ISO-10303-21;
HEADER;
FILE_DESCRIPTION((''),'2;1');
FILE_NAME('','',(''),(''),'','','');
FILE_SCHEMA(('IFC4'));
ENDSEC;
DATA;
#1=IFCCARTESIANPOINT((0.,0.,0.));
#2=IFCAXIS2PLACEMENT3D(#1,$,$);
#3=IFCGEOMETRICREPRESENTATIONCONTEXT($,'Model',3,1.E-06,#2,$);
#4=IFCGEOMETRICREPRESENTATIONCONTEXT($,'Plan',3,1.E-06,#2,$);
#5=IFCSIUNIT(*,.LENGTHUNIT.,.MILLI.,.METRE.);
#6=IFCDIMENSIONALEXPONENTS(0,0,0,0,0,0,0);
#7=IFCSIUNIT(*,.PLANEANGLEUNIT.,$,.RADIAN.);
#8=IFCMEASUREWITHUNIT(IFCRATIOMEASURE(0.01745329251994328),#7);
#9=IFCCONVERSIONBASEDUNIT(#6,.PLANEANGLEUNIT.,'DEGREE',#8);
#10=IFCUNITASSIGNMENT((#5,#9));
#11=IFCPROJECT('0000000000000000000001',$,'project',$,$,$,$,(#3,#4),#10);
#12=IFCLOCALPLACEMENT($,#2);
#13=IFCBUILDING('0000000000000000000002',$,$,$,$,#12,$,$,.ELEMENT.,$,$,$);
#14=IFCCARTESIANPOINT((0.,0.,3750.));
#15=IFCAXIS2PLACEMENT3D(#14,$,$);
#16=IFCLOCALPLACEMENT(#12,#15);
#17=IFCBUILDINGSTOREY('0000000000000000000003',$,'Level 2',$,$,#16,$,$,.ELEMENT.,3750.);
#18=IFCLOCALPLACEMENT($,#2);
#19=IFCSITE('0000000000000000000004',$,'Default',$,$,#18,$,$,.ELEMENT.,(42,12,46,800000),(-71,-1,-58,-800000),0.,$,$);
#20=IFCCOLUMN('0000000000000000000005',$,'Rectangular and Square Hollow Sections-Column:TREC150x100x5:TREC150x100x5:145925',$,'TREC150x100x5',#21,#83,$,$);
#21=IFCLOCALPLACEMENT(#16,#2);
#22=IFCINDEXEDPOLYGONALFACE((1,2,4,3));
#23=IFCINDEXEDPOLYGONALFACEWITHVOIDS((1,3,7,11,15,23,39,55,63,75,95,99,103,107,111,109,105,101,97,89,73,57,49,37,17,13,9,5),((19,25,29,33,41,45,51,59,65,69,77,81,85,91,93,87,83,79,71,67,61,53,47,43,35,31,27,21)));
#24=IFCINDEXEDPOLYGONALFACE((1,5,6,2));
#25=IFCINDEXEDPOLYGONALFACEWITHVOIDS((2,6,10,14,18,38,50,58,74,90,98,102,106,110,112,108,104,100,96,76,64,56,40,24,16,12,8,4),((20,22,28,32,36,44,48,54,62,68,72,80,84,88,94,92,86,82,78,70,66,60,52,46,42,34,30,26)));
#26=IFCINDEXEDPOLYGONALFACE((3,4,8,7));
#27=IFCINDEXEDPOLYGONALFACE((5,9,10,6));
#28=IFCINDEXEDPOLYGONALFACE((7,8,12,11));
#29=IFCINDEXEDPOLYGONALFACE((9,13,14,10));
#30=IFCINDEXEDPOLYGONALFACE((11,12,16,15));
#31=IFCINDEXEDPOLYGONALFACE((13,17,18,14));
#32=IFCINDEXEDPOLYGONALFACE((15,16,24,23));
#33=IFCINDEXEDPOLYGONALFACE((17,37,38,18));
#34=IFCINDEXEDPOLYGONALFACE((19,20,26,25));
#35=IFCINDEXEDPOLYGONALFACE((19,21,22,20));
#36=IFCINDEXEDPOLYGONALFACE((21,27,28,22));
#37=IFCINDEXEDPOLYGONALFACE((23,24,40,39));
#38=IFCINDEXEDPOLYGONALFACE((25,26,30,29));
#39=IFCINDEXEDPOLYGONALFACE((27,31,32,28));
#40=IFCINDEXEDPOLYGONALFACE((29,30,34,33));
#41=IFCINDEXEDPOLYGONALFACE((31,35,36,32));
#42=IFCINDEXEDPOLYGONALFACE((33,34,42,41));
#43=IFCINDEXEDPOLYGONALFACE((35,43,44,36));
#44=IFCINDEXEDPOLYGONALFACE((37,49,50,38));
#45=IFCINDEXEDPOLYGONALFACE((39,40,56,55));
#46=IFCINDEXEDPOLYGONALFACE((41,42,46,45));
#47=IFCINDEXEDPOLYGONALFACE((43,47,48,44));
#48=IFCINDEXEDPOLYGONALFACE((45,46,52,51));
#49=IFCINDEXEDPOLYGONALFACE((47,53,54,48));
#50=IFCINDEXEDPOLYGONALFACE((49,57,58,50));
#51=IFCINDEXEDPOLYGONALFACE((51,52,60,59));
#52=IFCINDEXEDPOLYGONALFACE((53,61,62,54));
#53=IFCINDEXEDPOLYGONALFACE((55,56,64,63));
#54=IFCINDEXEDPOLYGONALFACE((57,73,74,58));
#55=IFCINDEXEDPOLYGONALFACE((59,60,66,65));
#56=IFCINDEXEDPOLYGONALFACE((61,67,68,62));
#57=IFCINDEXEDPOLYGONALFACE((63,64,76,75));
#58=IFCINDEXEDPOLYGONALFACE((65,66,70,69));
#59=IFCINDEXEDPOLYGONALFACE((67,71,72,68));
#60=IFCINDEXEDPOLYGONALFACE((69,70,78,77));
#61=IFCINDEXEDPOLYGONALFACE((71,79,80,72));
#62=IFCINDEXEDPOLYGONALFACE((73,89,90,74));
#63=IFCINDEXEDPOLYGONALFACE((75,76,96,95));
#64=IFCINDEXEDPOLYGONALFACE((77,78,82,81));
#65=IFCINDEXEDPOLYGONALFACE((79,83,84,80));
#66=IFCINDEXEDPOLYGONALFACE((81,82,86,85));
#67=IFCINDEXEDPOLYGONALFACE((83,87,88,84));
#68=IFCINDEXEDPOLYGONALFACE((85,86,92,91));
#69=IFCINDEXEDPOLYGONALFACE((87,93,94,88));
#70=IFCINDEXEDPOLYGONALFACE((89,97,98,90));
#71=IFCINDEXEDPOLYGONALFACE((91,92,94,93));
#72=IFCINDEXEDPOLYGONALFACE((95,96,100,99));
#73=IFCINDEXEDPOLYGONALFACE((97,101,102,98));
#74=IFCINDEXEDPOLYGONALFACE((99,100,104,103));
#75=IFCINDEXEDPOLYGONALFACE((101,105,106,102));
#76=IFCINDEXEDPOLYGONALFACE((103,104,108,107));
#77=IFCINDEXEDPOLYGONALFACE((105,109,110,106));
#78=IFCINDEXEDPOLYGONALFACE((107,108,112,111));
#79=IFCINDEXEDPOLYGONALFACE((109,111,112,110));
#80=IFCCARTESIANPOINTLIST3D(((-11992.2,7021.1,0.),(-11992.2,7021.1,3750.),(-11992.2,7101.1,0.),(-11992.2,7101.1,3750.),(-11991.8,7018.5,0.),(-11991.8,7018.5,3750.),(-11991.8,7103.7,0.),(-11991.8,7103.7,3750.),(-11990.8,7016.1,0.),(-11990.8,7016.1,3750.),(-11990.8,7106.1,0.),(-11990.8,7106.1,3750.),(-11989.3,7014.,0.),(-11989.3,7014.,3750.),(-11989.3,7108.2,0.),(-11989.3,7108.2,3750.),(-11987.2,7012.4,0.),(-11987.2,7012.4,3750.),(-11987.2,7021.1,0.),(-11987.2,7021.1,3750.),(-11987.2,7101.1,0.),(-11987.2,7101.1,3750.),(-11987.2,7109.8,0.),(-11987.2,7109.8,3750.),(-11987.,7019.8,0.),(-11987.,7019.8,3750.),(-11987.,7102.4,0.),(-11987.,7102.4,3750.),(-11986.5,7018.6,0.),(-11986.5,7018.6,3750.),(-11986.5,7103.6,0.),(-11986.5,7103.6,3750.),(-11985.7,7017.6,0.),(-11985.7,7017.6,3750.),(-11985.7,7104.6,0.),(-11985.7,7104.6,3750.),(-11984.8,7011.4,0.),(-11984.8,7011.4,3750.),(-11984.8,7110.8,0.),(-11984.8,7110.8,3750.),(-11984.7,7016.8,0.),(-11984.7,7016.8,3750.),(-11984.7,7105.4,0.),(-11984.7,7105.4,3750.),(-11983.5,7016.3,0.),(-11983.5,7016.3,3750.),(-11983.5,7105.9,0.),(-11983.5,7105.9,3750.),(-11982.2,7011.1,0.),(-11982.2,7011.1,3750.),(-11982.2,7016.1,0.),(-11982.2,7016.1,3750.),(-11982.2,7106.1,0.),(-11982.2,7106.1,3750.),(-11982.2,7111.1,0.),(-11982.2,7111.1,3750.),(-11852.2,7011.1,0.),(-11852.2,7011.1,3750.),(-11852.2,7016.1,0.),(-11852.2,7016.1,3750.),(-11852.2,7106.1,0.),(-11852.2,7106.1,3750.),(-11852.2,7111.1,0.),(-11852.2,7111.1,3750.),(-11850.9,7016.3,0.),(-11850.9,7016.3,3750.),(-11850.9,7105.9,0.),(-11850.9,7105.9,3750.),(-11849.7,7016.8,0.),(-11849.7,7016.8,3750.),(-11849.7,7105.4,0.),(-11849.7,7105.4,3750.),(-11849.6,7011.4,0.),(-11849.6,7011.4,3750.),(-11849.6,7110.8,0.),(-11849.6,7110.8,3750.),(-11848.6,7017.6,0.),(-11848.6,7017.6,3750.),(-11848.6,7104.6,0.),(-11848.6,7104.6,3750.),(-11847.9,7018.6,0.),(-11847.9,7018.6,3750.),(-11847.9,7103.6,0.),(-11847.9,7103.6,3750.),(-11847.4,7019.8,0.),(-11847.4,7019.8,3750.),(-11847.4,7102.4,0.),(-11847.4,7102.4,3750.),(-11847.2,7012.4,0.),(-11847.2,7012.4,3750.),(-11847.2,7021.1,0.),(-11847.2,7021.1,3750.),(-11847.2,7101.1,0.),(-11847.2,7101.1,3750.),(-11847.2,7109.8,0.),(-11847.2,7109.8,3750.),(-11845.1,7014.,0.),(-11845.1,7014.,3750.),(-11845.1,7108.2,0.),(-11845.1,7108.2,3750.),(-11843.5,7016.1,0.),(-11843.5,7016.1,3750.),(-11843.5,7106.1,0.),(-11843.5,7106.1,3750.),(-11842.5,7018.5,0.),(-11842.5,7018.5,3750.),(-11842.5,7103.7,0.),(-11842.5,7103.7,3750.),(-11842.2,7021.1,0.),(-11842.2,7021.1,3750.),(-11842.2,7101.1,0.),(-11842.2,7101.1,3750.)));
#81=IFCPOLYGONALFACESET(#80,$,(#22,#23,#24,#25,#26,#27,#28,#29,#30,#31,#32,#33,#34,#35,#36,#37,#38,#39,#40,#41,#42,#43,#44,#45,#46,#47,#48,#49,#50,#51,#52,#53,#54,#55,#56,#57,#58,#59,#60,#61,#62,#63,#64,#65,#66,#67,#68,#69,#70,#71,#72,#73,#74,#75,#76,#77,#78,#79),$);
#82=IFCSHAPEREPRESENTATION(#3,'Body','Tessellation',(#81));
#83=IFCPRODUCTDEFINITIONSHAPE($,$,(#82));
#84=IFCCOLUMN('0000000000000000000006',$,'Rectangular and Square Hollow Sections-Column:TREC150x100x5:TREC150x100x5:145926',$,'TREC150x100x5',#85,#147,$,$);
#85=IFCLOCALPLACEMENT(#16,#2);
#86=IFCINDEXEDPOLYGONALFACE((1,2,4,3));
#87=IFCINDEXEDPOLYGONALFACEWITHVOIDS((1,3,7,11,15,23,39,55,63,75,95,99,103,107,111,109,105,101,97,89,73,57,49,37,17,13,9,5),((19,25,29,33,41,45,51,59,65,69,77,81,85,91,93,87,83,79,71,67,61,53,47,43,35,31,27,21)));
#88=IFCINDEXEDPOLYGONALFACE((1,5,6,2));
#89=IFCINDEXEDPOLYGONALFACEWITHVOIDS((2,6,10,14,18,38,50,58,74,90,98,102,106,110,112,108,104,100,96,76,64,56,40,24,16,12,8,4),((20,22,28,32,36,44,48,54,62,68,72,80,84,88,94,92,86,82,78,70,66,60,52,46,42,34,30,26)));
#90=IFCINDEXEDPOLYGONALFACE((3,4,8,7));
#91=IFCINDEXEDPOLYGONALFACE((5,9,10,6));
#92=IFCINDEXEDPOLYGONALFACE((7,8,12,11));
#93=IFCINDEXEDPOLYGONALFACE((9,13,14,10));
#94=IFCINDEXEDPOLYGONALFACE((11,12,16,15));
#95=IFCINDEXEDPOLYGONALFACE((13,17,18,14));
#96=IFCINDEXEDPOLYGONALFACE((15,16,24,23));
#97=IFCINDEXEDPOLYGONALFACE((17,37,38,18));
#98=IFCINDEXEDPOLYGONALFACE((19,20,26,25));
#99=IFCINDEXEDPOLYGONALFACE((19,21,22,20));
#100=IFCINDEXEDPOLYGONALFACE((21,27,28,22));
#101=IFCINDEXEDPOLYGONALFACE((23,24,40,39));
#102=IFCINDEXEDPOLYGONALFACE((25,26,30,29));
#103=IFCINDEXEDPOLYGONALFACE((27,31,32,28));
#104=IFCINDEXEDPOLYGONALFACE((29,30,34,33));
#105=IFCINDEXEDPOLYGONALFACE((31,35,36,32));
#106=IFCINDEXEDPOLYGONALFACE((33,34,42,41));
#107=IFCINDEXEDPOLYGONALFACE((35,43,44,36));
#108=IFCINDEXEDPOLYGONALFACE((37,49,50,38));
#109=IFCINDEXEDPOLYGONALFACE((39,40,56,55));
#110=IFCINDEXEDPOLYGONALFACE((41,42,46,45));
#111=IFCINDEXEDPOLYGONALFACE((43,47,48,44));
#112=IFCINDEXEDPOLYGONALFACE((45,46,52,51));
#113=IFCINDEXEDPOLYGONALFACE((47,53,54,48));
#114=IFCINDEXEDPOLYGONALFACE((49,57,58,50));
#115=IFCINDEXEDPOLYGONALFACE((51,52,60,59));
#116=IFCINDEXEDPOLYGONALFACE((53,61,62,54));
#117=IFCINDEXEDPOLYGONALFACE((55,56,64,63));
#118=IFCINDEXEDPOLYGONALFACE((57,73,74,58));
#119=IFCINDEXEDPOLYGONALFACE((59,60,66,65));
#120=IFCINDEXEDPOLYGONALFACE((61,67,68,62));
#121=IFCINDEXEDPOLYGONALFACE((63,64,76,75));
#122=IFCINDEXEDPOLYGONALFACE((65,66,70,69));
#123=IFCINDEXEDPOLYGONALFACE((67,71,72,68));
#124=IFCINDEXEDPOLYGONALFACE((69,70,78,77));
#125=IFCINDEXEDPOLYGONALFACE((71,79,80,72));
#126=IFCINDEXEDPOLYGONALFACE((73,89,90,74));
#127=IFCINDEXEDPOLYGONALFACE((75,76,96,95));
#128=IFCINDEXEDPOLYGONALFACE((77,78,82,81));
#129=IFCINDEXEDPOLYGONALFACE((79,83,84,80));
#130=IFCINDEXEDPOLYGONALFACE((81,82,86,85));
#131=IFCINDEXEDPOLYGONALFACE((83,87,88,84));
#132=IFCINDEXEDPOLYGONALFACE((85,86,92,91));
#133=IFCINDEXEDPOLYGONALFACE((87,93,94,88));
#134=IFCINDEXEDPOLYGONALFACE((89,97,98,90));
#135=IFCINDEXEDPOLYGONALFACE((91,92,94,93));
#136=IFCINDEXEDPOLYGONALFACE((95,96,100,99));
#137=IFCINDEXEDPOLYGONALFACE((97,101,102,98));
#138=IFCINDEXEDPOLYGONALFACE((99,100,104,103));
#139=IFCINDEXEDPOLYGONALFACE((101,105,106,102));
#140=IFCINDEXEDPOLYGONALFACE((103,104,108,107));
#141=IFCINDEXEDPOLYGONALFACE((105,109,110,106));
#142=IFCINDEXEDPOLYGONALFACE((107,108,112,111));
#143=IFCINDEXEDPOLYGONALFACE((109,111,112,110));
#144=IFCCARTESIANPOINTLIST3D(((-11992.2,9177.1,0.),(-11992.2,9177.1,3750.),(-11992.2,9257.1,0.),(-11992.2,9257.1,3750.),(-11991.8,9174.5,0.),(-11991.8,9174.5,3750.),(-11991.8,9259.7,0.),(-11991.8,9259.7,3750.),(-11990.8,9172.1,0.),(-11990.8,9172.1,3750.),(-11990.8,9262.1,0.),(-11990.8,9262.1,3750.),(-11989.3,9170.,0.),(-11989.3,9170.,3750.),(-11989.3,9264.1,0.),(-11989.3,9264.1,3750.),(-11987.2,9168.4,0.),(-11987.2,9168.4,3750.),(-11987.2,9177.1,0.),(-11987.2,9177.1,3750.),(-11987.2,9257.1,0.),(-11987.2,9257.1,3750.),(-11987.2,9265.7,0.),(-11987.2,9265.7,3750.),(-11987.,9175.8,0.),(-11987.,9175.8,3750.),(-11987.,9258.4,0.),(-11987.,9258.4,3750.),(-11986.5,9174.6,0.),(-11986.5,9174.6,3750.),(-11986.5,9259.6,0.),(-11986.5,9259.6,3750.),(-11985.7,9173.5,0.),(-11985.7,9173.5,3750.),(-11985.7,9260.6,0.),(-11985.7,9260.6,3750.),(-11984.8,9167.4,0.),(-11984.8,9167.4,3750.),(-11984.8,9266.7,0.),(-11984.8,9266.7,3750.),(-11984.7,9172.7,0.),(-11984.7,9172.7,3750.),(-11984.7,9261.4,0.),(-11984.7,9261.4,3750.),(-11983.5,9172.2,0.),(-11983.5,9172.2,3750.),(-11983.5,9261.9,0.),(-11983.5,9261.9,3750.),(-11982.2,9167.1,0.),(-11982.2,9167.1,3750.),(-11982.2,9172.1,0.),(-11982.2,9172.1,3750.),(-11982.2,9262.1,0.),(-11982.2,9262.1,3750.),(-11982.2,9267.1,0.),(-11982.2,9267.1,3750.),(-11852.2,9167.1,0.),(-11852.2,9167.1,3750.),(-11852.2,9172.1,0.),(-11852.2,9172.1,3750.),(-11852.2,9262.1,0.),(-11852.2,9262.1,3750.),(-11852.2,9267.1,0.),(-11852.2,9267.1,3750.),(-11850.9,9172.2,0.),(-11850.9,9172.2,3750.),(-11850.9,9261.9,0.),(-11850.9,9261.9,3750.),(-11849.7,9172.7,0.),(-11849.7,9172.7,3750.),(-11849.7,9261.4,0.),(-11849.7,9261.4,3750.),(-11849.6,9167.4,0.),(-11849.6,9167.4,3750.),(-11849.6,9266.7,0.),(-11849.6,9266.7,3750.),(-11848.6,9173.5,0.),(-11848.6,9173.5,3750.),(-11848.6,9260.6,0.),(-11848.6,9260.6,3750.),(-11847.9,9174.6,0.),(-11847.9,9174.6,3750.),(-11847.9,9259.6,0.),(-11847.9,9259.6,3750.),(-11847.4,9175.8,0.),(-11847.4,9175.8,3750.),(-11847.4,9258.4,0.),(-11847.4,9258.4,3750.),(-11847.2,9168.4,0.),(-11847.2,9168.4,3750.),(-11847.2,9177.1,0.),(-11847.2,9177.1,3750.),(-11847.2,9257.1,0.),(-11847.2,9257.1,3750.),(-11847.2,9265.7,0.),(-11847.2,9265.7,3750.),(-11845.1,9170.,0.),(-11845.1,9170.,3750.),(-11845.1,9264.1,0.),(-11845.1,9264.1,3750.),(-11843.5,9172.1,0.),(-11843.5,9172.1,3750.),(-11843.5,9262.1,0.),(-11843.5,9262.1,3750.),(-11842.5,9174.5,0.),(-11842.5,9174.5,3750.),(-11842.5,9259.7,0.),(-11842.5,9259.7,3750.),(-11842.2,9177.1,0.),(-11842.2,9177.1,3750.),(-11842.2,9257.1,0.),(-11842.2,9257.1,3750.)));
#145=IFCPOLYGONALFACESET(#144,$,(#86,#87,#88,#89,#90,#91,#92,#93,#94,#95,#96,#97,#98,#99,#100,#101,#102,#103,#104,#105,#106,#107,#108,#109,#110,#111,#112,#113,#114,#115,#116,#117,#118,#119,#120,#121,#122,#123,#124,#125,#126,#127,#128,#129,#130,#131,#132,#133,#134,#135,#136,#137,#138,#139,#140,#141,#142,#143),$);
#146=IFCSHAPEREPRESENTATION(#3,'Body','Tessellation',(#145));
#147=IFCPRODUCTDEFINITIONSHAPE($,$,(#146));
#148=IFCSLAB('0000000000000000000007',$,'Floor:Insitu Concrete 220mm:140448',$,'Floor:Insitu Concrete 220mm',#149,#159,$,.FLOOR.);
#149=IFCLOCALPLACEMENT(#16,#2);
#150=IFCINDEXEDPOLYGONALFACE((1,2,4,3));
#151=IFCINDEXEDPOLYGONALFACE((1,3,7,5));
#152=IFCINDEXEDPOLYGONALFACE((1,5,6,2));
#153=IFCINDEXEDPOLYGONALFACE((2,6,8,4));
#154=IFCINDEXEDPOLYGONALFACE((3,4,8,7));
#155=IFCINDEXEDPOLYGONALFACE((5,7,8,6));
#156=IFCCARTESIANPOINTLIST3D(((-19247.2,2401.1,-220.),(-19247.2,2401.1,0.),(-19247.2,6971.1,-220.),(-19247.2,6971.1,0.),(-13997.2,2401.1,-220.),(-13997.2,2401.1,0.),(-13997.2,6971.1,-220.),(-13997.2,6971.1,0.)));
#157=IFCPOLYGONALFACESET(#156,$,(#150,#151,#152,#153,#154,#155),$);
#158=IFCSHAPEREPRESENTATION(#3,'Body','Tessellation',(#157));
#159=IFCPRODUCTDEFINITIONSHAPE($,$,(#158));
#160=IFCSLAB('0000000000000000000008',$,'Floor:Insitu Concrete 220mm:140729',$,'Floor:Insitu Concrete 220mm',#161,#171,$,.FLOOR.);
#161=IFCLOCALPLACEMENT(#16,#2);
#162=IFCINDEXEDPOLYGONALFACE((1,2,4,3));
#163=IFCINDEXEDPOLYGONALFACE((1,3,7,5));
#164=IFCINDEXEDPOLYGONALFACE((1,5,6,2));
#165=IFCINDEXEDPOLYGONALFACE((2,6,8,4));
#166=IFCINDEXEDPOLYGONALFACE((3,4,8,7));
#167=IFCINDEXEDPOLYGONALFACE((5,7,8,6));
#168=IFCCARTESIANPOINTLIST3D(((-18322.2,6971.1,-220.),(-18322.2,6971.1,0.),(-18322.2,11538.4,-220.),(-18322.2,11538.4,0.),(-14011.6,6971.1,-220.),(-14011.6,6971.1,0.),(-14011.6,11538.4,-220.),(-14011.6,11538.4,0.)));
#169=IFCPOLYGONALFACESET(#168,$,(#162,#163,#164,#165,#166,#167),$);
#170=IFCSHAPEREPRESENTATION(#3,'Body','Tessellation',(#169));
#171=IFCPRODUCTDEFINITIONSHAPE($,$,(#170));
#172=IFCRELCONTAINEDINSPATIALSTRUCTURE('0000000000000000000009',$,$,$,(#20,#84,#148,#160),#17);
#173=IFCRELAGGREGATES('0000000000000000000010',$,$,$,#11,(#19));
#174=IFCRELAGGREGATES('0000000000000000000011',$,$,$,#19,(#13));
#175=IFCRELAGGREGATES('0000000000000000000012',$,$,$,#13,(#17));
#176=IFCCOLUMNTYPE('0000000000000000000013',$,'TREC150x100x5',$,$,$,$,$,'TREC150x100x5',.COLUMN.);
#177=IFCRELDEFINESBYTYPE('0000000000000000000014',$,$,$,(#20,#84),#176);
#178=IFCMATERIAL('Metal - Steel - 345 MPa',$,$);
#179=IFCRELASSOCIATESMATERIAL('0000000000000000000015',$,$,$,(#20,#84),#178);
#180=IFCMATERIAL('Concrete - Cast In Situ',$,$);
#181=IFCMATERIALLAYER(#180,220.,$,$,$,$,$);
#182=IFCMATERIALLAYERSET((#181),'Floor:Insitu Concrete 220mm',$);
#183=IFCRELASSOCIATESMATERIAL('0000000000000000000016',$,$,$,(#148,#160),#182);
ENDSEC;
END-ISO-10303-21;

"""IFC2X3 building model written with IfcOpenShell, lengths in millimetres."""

from ifc_helpers import new_model, entity, si_unit, converted_unit, frame, frame_2d, origin, place, context, project, spatial, polyline, circle_curve, parameter, trimmed, segment, composite_curve, rectangle, outline, extrude, source, transform, mapped, material, layer, layer_set, layer_usage, type_object, type_shapes, element, save


model = new_model("IFC2X3")

# Units and contexts
model_context = context("Model", 3, precision=1e-06, world=origin())
plan_context = context("Plan", 3, precision=1e-06, world=origin())
ifc_project = project(units=[si_unit("LENGTHUNIT", "METRE", prefix="MILLI"), converted_unit("PLANEANGLEUNIT", "DEGREE", entity("IfcRatioMeasure", 0.01745329251994328), si_unit("PLANEANGLEUNIT", "RADIAN"), dimensions=[0, 0, 0, 0, 0, 0, 0])], contexts=[model_context, plan_context])

# Site, building, storey
site_placement = place(None, origin())
site = spatial("IfcSite", under=ifc_project, at=site_placement, Name="Default", CompositionType="ELEMENT", RefLatitude=(42, 12, 46, 800000), RefLongitude=(-71, -1, -58, -800000), RefElevation=0.0)
building_placement = place(None, origin())
building = spatial("IfcBuilding", under=site, at=building_placement, CompositionType="ELEMENT")
storey_placement = place(building_placement, frame((0.0, 0.0, 3750.0)))
storey = spatial("IfcBuildingStorey", under=building, at=storey_placement, Name="Level 2", CompositionType="ELEMENT", Elevation=3750.0)

# Columns
ifc_material_1 = material(Name="Metal - Steel - 345 MPa")
column_type = type_object("IfcColumnType", Name="TREC150x100x5", ElementType="TREC150x100x5", PredefinedType="COLUMN")
shared_shape = source(origin(), model_context, "Body", "SweptSolid", [
    extrude(outline(composite_curve([segment(polyline([(-40.0, -75.0), (40.0, -75.0)]), True, "CONTINUOUS"), segment(trimmed(circle_curve(frame_2d((40.0, -65.0), x_axis=(-1.0, 0.0)), 10.0), [parameter(90.0)], [parameter(180.0)], True, "PARAMETER"), True, "CONTINUOUS"), segment(polyline([(50.0, -65.0), (50.0, 65.0)]), True, "CONTINUOUS"), segment(trimmed(circle_curve(frame_2d((40.0, 65.0), x_axis=(-1.0, 0.0)), 10.0), [parameter(180.0)], [parameter(270.0)], True, "PARAMETER"), True, "CONTINUOUS"), segment(polyline([(40.0, 75.0), (-40.0, 75.0)]), True, "CONTINUOUS"), segment(trimmed(circle_curve(frame_2d((-40.0, 65.0), x_axis=(-1.0, 0.0)), 10.0), [parameter(270.0)], [parameter(360.0)], True, "PARAMETER"), True, "CONTINUOUS"), segment(polyline([(-50.0, 65.0), (-50.0, -65.0)]), True, "CONTINUOUS"), segment(trimmed(circle_curve(frame_2d((-40.0, -65.0), x_axis=(-1.0, 0.0)), 10.0), [parameter(360.0)], [parameter(90.0)], True, "PARAMETER"), True, "CONTINUOUS")], self_intersect=False), holes=[composite_curve([segment(trimmed(circle_curve(frame_2d((-40.0, -65.0), x_axis=(-1.0, 0.0)), 5.0), [parameter(0.0)], [parameter(90.0)], True, "PARAMETER"), False, "CONTINUOUS"), segment(polyline([(-45.0, -65.0), (-45.0, 65.0)]), True, "CONTINUOUS"), segment(trimmed(circle_curve(frame_2d((-40.0, 65.0), x_axis=(-1.0, 0.0)), 5.0), [parameter(270.0)], [parameter(360.0)], True, "PARAMETER"), False, "CONTINUOUS"), segment(polyline([(-40.0, 70.0), (40.0, 70.0)]), True, "CONTINUOUS"), segment(trimmed(circle_curve(frame_2d((40.0, 65.0), x_axis=(-1.0, 0.0)), 5.0), [parameter(180.0)], [parameter(270.0)], True, "PARAMETER"), False, "CONTINUOUS"), segment(polyline([(45.0, 65.0), (45.0, -65.0)]), True, "CONTINUOUS"), segment(trimmed(circle_curve(frame_2d((40.0, -65.0), x_axis=(-1.0, 0.0)), 5.0), [parameter(90.0)], [parameter(180.0)], True, "PARAMETER"), False, "CONTINUOUS"), segment(polyline([(40.0, -70.0), (-40.0, -70.0)]), True, "CONTINUOUS")], self_intersect=False)]), frame((0.0, 0.0, 3750.0), z_axis=(0.0, 0.0, 1.0), x_axis=(-1.0, 0.0, 0.0)), (0.0, 0.0, 1.0), 3750.0),
])
type_shapes(column_type, [shared_shape])
for number, where, z_axis, x_axis, name in (
    (1, (-11917.2, 7061.1, -3750.0), (0.0, 0.0, 1.0), (0.0, 1.0, 0.0), "Rectangular and Square Hollow Sections-Column:TREC150x100x5:TREC150x100x5:145925"),
    (2, (-11917.2, 9217.1, -3750.0), (0.0, 0.0, 1.0), (0.0, 1.0, 0.0), "Rectangular and Square Hollow Sections-Column:TREC150x100x5:TREC150x100x5:145926"),
):
    element("IfcColumn", number, at=place(storey_placement, frame(where, z_axis=z_axis, x_axis=x_axis)), inside=storey, type_object=column_type, material=ifc_material_1, Name=name, ObjectType="TREC150x100x5", context=model_context, shape_type="MappedRepresentation", body=[
        mapped(shared_shape, transform((0.0, 0.0, 0.0), scale=1.0)),
    ])

# Slabs
ifc_material_2 = material(Name="Concrete - Cast In Situ")
ifc_layer_1 = layer(ifc_material_2, 220.0)
ifc_layer_set_1 = layer_set([ifc_layer_1], Name="Floor:Insitu Concrete 220mm")
ifc_layer_usage_1 = layer_usage(ifc_layer_set_1, "AXIS3", "POSITIVE", 0.0)
slab_1_placement = place(storey_placement, frame((-19247.2, 2401.1, -220.0)))
element("IfcSlab", 3, at=slab_1_placement, inside=storey, material=ifc_layer_usage_1, Name="Floor:Insitu Concrete 220mm:140448", ObjectType="Floor:Insitu Concrete 220mm", PredefinedType="FLOOR", context=model_context, shape_type="SweptSolid", body=[
    extrude(rectangle(XDim=4570.0, YDim=5250.0, at=frame_2d((16622.2, 4686.1), x_axis=(0.0, -1.0))), frame((19247.2, -2401.1, 220.0), z_axis=(0.0, 0.0, -1.0), x_axis=(-1.0, 0.0, 0.0)), (0.0, 0.0, 1.0), 220.0),
])
ifc_layer_usage_2 = layer_usage(ifc_layer_set_1, "AXIS3", "POSITIVE", 0.0)
slab_2_placement = place(storey_placement, frame((-18322.2, 6971.1, -220.0)))
element("IfcSlab", 4, at=slab_2_placement, inside=storey, material=ifc_layer_usage_2, Name="Floor:Insitu Concrete 220mm:140729", ObjectType="Floor:Insitu Concrete 220mm", PredefinedType="FLOOR", context=model_context, shape_type="SweptSolid", body=[
    extrude(rectangle(XDim=4567.3, YDim=4310.6, at=frame_2d((16166.9, 9254.7), x_axis=(0.0, -1.0))), frame((18322.2, -6971.1, 220.0), z_axis=(0.0, 0.0, -1.0), x_axis=(-1.0, 0.0, 0.0)), (0.0, 0.0, 1.0), 220.0),
])

save(model, "model.ifc")
